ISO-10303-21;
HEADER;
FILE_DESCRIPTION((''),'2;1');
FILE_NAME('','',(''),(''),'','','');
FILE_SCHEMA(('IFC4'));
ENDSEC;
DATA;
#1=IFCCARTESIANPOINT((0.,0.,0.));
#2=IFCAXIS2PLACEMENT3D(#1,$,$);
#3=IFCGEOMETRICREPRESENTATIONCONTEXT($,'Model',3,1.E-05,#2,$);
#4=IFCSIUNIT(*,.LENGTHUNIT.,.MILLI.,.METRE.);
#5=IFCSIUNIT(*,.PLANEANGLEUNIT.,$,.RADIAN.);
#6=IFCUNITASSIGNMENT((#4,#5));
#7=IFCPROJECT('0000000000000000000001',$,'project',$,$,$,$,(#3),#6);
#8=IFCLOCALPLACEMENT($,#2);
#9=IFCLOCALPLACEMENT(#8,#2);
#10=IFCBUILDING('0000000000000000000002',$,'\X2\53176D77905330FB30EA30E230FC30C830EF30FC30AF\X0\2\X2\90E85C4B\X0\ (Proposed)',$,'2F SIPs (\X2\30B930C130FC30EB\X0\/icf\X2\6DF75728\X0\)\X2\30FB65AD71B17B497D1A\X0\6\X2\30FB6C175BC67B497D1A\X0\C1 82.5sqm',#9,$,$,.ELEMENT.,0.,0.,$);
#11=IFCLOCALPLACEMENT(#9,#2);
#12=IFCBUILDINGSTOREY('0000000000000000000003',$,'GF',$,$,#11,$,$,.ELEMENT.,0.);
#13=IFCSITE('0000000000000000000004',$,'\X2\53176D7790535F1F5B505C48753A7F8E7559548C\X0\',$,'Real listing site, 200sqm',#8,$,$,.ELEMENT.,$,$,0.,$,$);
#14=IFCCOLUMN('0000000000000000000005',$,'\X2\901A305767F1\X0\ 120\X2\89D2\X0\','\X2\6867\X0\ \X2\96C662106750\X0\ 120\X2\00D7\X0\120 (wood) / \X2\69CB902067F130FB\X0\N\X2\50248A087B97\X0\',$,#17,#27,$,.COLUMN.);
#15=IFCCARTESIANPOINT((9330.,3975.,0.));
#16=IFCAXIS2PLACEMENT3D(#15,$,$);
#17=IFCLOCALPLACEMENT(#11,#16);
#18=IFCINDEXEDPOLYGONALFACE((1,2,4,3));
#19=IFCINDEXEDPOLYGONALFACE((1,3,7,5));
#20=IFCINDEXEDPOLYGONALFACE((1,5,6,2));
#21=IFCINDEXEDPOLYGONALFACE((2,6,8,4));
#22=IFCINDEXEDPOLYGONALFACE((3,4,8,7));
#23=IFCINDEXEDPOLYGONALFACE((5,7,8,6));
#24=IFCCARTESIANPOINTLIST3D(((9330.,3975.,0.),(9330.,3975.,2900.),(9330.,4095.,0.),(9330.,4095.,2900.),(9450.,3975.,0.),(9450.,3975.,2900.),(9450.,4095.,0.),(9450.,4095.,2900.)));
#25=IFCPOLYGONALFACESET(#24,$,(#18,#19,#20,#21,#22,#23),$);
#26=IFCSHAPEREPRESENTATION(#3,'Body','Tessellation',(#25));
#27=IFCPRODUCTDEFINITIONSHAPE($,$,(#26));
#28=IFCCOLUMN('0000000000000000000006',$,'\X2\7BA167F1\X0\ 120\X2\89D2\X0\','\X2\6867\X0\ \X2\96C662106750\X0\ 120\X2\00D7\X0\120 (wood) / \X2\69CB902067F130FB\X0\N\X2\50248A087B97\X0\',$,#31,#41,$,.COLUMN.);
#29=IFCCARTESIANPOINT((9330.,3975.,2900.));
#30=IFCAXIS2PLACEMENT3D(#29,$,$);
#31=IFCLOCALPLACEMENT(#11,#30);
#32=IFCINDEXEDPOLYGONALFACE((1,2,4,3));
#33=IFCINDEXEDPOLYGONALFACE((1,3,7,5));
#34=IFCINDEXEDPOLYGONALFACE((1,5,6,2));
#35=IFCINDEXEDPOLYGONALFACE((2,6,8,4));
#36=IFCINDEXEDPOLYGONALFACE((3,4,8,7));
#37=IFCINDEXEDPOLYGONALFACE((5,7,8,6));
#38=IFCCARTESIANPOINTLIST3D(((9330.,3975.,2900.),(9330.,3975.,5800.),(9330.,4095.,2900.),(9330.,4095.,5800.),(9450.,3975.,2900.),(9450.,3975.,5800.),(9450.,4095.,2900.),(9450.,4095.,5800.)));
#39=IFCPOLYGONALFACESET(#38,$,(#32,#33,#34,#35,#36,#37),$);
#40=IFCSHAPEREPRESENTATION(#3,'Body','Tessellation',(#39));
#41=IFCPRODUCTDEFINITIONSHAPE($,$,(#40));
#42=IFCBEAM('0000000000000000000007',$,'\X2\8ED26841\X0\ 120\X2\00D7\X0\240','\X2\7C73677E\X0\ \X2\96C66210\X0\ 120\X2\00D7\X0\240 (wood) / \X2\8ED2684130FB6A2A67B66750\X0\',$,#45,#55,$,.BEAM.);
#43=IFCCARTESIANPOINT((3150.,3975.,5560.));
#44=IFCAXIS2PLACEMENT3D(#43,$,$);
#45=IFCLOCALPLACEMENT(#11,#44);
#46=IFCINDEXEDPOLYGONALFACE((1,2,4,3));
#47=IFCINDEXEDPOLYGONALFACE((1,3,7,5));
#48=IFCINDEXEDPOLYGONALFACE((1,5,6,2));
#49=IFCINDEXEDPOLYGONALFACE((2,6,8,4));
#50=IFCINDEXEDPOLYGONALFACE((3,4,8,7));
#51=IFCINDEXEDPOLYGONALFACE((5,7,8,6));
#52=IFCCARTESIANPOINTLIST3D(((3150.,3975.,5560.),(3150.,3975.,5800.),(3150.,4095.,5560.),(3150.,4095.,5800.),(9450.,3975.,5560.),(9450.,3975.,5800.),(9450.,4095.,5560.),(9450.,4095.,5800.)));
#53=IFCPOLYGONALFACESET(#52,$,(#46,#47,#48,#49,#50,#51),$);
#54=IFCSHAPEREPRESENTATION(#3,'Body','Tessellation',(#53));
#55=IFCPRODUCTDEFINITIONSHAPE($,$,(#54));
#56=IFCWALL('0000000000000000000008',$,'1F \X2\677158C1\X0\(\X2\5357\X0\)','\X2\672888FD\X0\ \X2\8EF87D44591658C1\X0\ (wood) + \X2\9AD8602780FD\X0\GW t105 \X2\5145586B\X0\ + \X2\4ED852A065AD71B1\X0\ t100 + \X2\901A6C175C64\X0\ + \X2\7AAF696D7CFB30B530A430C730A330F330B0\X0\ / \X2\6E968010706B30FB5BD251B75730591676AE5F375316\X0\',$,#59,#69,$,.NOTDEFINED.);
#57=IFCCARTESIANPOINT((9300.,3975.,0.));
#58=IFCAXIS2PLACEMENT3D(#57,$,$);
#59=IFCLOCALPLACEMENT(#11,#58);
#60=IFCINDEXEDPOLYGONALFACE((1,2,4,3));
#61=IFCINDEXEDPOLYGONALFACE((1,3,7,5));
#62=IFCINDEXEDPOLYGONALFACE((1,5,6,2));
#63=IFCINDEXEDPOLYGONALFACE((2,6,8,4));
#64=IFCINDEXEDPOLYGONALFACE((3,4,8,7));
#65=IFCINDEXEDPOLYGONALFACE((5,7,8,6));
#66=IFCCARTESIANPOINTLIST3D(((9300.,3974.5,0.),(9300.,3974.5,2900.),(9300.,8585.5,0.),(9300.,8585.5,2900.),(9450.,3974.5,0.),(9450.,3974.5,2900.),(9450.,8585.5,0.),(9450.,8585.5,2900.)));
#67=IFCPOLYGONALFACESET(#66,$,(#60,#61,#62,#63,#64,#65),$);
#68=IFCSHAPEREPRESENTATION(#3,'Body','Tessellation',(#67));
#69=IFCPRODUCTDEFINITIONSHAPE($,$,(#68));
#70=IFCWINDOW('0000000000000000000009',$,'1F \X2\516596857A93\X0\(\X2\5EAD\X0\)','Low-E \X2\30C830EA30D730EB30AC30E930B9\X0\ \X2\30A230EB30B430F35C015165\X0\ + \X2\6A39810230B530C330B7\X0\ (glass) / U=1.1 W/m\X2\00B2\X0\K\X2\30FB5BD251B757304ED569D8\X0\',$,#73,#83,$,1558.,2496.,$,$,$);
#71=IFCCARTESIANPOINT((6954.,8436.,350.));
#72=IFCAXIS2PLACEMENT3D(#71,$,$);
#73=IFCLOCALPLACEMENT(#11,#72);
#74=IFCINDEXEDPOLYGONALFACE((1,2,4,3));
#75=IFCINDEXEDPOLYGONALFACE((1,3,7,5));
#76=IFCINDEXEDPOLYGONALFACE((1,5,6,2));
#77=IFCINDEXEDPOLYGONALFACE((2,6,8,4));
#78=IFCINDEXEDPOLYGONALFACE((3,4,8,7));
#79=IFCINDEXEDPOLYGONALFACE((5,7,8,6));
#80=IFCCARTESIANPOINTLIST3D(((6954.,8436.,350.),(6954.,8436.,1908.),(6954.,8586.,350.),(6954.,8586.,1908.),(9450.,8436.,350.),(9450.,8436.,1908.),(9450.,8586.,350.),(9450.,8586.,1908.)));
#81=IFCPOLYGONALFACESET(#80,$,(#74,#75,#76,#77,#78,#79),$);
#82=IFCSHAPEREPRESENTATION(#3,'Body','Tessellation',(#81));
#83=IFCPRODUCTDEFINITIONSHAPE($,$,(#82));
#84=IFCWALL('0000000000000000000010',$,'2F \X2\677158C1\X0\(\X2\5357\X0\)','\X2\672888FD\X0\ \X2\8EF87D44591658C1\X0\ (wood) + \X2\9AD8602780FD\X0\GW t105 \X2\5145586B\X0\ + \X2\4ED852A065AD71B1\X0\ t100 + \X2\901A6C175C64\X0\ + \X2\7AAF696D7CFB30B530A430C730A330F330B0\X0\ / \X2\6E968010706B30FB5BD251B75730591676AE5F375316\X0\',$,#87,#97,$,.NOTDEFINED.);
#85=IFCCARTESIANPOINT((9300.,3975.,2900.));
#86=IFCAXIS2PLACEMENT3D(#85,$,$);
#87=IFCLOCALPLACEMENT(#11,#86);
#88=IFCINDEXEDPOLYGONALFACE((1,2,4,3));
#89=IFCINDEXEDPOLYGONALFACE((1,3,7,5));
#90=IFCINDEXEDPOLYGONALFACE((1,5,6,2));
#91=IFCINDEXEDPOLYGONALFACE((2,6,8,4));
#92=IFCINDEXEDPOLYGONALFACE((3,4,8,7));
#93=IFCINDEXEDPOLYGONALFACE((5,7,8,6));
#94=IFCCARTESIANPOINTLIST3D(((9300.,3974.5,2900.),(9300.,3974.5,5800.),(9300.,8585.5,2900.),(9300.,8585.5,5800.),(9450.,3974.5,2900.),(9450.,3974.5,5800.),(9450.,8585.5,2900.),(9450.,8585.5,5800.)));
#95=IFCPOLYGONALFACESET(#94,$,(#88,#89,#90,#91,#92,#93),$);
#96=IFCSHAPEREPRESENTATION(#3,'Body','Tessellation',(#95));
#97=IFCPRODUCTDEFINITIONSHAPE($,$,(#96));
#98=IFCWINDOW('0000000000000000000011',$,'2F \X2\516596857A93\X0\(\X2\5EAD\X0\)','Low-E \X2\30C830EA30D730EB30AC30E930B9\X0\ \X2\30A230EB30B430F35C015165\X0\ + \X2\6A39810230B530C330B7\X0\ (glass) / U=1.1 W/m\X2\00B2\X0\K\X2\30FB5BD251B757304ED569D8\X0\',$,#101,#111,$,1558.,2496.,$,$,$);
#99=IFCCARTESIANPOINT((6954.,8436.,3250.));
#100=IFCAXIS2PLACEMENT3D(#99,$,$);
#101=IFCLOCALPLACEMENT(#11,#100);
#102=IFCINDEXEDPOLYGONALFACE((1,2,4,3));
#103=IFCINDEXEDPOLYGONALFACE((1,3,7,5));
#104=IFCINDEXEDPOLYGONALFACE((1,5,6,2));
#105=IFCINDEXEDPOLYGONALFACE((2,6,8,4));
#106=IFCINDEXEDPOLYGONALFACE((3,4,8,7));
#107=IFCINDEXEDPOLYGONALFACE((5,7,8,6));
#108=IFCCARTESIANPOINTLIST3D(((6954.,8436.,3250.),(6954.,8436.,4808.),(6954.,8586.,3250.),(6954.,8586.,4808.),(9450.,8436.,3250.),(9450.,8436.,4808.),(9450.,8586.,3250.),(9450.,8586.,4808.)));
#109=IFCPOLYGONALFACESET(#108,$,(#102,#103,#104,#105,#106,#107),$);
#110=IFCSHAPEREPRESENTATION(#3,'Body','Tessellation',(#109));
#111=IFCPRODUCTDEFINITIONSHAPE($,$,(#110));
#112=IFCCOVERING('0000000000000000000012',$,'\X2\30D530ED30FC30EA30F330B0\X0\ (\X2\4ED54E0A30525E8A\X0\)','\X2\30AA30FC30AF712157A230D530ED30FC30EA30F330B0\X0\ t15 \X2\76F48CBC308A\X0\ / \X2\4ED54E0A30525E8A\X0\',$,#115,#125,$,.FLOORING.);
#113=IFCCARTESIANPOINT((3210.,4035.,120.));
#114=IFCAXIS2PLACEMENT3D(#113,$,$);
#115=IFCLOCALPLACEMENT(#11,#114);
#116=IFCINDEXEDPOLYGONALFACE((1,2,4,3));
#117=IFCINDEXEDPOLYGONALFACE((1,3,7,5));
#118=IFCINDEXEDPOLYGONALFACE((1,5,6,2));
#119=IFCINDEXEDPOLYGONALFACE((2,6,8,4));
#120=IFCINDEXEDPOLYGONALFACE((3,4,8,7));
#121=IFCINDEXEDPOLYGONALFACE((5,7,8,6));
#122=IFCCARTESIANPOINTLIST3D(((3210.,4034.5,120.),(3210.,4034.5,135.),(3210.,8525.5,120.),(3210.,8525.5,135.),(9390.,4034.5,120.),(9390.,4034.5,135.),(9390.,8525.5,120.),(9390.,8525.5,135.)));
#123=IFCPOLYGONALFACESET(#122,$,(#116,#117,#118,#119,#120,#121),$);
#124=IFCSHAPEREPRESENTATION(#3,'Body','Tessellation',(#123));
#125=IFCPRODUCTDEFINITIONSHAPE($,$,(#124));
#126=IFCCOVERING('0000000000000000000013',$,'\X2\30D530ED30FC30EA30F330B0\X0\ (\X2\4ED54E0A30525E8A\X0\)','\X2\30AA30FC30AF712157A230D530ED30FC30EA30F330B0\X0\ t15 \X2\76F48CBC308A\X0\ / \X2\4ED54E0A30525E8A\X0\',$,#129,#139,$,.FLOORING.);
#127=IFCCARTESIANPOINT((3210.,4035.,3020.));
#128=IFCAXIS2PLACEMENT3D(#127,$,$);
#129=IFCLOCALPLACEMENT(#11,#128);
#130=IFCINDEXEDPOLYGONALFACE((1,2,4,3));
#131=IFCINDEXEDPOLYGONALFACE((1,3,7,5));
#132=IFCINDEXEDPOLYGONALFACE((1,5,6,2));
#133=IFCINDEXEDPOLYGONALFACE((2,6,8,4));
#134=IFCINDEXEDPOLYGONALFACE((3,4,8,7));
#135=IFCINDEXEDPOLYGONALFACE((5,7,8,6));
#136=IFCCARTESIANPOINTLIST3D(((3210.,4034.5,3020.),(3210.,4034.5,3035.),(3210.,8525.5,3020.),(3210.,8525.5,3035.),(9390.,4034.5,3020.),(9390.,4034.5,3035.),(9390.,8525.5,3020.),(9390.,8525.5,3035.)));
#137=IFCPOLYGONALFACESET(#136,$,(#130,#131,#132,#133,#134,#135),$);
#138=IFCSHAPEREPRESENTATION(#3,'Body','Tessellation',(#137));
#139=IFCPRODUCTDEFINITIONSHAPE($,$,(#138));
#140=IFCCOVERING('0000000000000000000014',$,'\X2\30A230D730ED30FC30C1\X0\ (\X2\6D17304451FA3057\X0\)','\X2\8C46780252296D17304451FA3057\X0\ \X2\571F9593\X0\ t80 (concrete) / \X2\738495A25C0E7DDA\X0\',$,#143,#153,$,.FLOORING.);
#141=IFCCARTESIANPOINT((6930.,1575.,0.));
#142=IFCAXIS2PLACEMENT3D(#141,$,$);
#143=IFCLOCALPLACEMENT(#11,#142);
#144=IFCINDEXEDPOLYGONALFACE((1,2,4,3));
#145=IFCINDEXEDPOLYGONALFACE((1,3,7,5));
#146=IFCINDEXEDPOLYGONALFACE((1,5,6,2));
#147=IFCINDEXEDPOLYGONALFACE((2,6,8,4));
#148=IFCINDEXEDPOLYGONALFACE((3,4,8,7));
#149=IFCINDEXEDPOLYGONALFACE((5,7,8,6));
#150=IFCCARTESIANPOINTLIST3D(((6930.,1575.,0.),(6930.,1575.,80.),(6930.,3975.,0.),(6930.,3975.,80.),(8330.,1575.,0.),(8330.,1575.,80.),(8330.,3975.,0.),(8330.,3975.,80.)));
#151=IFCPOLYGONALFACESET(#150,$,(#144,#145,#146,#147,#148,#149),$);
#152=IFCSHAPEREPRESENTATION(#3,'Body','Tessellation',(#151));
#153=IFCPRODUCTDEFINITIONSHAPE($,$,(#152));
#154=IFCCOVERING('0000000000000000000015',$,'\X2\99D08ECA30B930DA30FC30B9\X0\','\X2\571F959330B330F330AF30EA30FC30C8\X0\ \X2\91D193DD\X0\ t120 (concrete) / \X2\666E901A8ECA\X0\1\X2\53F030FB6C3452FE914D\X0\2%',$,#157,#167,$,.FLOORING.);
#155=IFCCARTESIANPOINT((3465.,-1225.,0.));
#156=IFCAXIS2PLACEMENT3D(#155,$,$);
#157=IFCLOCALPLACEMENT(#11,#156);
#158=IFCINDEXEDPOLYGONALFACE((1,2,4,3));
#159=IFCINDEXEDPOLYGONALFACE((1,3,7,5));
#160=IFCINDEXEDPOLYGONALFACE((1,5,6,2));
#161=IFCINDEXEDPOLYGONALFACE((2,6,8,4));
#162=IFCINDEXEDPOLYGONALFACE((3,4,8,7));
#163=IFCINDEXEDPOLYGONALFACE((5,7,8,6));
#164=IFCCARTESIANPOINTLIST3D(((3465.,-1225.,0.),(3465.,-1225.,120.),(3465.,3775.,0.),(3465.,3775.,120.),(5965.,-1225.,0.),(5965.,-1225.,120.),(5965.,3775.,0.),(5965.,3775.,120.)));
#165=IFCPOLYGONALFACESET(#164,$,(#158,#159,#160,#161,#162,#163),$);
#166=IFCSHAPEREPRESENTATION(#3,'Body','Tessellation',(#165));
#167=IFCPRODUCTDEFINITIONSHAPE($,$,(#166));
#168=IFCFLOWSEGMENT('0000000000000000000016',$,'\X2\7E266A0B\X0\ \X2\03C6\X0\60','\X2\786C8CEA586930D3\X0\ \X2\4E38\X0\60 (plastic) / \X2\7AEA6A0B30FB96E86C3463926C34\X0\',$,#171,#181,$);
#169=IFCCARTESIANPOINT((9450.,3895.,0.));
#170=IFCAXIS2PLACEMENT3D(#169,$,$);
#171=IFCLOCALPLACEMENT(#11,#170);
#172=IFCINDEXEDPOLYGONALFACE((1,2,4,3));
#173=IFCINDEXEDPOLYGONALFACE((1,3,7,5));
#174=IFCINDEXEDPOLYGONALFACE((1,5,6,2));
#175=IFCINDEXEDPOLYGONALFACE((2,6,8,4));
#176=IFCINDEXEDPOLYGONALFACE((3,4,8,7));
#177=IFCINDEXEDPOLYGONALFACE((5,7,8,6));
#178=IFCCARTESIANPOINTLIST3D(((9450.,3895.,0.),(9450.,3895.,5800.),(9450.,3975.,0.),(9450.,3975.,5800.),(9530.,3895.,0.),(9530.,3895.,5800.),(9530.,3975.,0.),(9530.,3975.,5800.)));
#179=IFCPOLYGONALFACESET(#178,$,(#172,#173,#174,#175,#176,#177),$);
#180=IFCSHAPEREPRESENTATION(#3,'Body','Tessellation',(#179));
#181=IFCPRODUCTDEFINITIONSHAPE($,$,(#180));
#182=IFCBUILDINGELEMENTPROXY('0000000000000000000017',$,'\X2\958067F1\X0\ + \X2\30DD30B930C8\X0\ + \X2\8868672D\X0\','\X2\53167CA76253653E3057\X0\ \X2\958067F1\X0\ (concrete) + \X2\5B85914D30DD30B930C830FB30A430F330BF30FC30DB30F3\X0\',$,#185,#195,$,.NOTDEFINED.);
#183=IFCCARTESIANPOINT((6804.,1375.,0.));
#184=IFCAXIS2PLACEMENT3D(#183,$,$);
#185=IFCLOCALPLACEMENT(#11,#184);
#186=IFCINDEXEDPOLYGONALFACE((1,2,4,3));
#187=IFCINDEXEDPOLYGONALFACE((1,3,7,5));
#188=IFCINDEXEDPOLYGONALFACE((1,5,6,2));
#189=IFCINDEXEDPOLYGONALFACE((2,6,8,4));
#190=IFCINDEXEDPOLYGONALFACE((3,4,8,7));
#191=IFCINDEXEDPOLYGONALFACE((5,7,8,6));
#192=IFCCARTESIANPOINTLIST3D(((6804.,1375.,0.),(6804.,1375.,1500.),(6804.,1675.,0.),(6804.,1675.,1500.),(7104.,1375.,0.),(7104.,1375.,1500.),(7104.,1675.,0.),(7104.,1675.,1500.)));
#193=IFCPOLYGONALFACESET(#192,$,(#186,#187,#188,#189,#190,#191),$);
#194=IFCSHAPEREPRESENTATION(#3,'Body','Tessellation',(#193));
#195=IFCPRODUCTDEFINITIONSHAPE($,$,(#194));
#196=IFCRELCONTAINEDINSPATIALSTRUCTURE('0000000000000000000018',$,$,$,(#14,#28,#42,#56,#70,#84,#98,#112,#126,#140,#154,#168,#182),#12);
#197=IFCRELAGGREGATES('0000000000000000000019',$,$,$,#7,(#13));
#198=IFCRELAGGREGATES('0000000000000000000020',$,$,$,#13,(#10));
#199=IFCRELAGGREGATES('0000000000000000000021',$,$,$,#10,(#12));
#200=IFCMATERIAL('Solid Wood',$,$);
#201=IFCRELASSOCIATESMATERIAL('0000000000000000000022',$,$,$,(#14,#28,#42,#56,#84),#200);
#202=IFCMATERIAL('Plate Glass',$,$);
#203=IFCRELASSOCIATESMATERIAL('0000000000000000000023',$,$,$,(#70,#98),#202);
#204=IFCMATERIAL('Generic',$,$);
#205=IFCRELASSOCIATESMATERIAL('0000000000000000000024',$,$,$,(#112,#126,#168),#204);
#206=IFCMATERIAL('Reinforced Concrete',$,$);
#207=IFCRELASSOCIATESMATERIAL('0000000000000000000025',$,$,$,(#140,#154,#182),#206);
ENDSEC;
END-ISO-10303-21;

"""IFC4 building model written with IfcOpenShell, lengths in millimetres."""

from ifc_helpers import new_model, si_unit, frame, frame_2d, origin, place, context, project, spatial, rectangle, extrude, material, element, fill, save


model = new_model("IFC4")

# Units and contexts
model_context = context("Model", 3, precision=1e-05, world=origin())
ifc_project = project(units=[si_unit("LENGTHUNIT", "METRE", prefix="MILLI"), si_unit("PLANEANGLEUNIT", "RADIAN")], contexts=[model_context])

# Site, building, storey
site_placement = place(None, origin())
site = spatial("IfcSite", under=ifc_project, at=site_placement, Name="北海道弟子屈町美留和", ObjectType="Real listing site, 200sqm", CompositionType="ELEMENT", RefElevation=0.0)
building_placement = place(site_placement, origin())
building = spatial("IfcBuilding", under=site, at=building_placement, Name="北海道・リモートワーク2部屋 (Proposed)", ObjectType="2F SIPs (スチール/icf混在)・断熱等級6・気密等級C1 82.5sqm", CompositionType="ELEMENT", ElevationOfRefHeight=0.0, ElevationOfTerrain=0.0)
storey_placement = place(building_placement, origin())
storey = spatial("IfcBuildingStorey", under=building, at=storey_placement, Name="GF", CompositionType="ELEMENT", Elevation=0.0)

# Columns
ifc_material_1 = material(Name="Solid Wood")
column_1_placement = place(storey_placement, frame((9330.0, 3975.0, 0.0)))
element("IfcColumn", 1, at=column_1_placement, inside=storey, material=ifc_material_1, Name="通し柱 120角", Description="桧 集成材 120×120 (wood) / 構造柱・N値計算", PredefinedType="COLUMN", context=model_context, shape_type="SweptSolid", body=[
    extrude(rectangle(XDim=120.0, YDim=120.0, at=frame_2d((60.0, 60.0))), frame((9330.0, 3975.0, 0.0)), (0.0, 0.0, 1.0), 2900.0),
])
column_2_placement = place(storey_placement, frame((9330.0, 3975.0, 2900.0)))
element("IfcColumn", 2, at=column_2_placement, inside=storey, material=ifc_material_1, Name="管柱 120角", Description="桧 集成材 120×120 (wood) / 構造柱・N値計算", PredefinedType="COLUMN", context=model_context, shape_type="SweptSolid", body=[
    extrude(rectangle(XDim=120.0, YDim=120.0, at=frame_2d((60.0, 60.0))), frame((9330.0, 3975.0, 2900.0)), (0.0, 0.0, 1.0), 2900.0),
])

# Beam
beam_1_placement = place(storey_placement, frame((3150.0, 3975.0, 5560.0)))
element("IfcBeam", 3, at=beam_1_placement, inside=storey, material=ifc_material_1, Name="軒桁 120×240", Description="米松 集成 120×240 (wood) / 軒桁・横架材", PredefinedType="BEAM", context=model_context, shape_type="SweptSolid", body=[
    extrude(rectangle(XDim=6300.0, YDim=120.0, at=frame_2d((3150.0, 60.0))), frame((3150.0, 3975.0, 5560.0)), (0.0, 0.0, 1.0), 240.0),
])

# Wall, opening, window
wall_1_placement = place(storey_placement, frame((9300.0, 3975.0, 0.0)))
wall_1 = element("IfcWall", 4, at=wall_1_placement, inside=storey, material=ifc_material_1, Name="1F 東壁(南)", Description="木製 軸組外壁 (wood) + 高性能GW t105 充填 + 付加断熱 t100 + 通気層 + 窯業系サイディング / 準耐火・寒冷地外皮強化", PredefinedType="NOTDEFINED", context=model_context, shape_type="SweptSolid", body=[
    extrude(rectangle(XDim=150.0, YDim=4611.0, at=frame_2d((75.0, 2305.0))), frame((9300.0, 3975.0, 0.0)), (0.0, 0.0, 1.0), 2900.0),
])
opening_1_placement = place(storey_placement, frame((6954.0, 8436.0, 350.0)))
opening_1 = element("IfcOpeningElement", 5, at=opening_1_placement, cuts=wall_1, PredefinedType="NOTDEFINED", context=model_context, shape_type="SweptSolid", body=[
    extrude(rectangle(XDim=2496.0, YDim=150.0, at=frame_2d((1248.0, 75.0))), frame((6954.0, 8436.0, 350.0)), (0.0, 0.0, 1.0), 1558.0),
])
ifc_material_2 = material(Name="Plate Glass")
window_1_placement = place(storey_placement, frame((6954.0, 8436.0, 350.0)))
window_1 = element("IfcWindow", 6, at=window_1_placement, inside=storey, material=ifc_material_2, Name="1F 入隅窓(庭)", Description="Low-E トリプルガラス アルゴン封入 + 樹脂サッシ (glass) / U=1.1 W/m²K・寒冷地仕様", OverallHeight=1558.0, OverallWidth=2496.0, context=model_context, shape_type="SweptSolid", body=[
    extrude(rectangle(XDim=2496.0, YDim=150.0, at=frame_2d((1248.0, 75.0))), frame((6954.0, 8436.0, 350.0)), (0.0, 0.0, 1.0), 1558.0),
])
fill(opening_1, window_1)

# Wall, opening, window
wall_2_placement = place(storey_placement, frame((9300.0, 3975.0, 2900.0)))
wall_2 = element("IfcWall", 7, at=wall_2_placement, inside=storey, material=ifc_material_1, Name="2F 東壁(南)", Description="木製 軸組外壁 (wood) + 高性能GW t105 充填 + 付加断熱 t100 + 通気層 + 窯業系サイディング / 準耐火・寒冷地外皮強化", PredefinedType="NOTDEFINED", context=model_context, shape_type="SweptSolid", body=[
    extrude(rectangle(XDim=150.0, YDim=4611.0, at=frame_2d((75.0, 2305.0))), frame((9300.0, 3975.0, 2900.0)), (0.0, 0.0, 1.0), 2900.0),
])
opening_2_placement = place(storey_placement, frame((6954.0, 8436.0, 3250.0)))
opening_2 = element("IfcOpeningElement", 8, at=opening_2_placement, cuts=wall_2, PredefinedType="NOTDEFINED", context=model_context, shape_type="SweptSolid", body=[
    extrude(rectangle(XDim=2496.0, YDim=150.0, at=frame_2d((1248.0, 75.0))), frame((6954.0, 8436.0, 3250.0)), (0.0, 0.0, 1.0), 1558.0),
])
window_2_placement = place(storey_placement, frame((6954.0, 8436.0, 3250.0)))
window_2 = element("IfcWindow", 9, at=window_2_placement, inside=storey, material=ifc_material_2, Name="2F 入隅窓(庭)", Description="Low-E トリプルガラス アルゴン封入 + 樹脂サッシ (glass) / U=1.1 W/m²K・寒冷地仕様", OverallHeight=1558.0, OverallWidth=2496.0, context=model_context, shape_type="SweptSolid", body=[
    extrude(rectangle(XDim=2496.0, YDim=150.0, at=frame_2d((1248.0, 75.0))), frame((6954.0, 8436.0, 3250.0)), (0.0, 0.0, 1.0), 1558.0),
])
fill(opening_2, window_2)

# Coverings
ifc_material_3 = material(Name="Generic")
covering_1_placement = place(storey_placement, frame((3210.0, 4035.0, 120.0)))
element("IfcCovering", 10, at=covering_1_placement, inside=storey, material=ifc_material_3, Name="フローリング (仕上げ床)", Description="オーク無垢フローリング t15 直貼り / 仕上げ床", PredefinedType="FLOORING", context=model_context, shape_type="SweptSolid", body=[
    extrude(rectangle(XDim=6180.0, YDim=4491.0, at=frame_2d((3090.0, 2245.0))), frame((3210.0, 4035.0, 120.0)), (0.0, 0.0, 1.0), 15.0),
])
covering_2_placement = place(storey_placement, frame((3210.0, 4035.0, 3020.0)))
element("IfcCovering", 11, at=covering_2_placement, inside=storey, material=ifc_material_3, Name="フローリング (仕上げ床)", Description="オーク無垢フローリング t15 直貼り / 仕上げ床", PredefinedType="FLOORING", context=model_context, shape_type="SweptSolid", body=[
    extrude(rectangle(XDim=6180.0, YDim=4491.0, at=frame_2d((3090.0, 2245.0))), frame((3210.0, 4035.0, 3020.0)), (0.0, 0.0, 1.0), 15.0),
])
ifc_material_4 = material(Name="Reinforced Concrete")
covering_3_placement = place(storey_placement, frame((6930.0, 1575.0, 0.0)))
element("IfcCovering", 12, at=covering_3_placement, inside=storey, material=ifc_material_4, Name="アプローチ (洗い出し)", Description="豆砂利洗い出し 土間 t80 (concrete) / 玄関導線", PredefinedType="FLOORING", context=model_context, shape_type="SweptSolid", body=[
    extrude(rectangle(XDim=1400.0, YDim=2400.0, at=frame_2d((700.0, 1200.0))), frame((6930.0, 1575.0, 0.0)), (0.0, 0.0, 1.0), 80.0),
])
covering_4_placement = place(storey_placement, frame((3465.0, -1225.0, 0.0)))
element("IfcCovering", 13, at=covering_4_placement, inside=storey, material=ifc_material_4, Name="駐車スペース", Description="土間コンクリート 金鏝 t120 (concrete) / 普通車1台・水勾配2%", PredefinedType="FLOORING", context=model_context, shape_type="SweptSolid", body=[
    extrude(rectangle(XDim=2500.0, YDim=5000.0, at=frame_2d((1250.0, 2500.0))), frame((3465.0, -1225.0, 0.0)), (0.0, 0.0, 1.0), 120.0),
])

# Flow segment
flow_segment_placement = place(storey_placement, frame((9450.0, 3895.0, 0.0)))
element("IfcFlowSegment", 14, at=flow_segment_placement, inside=storey, material=ifc_material_3, Name="縦樋 φ60", Description="硬質塩ビ 丸60 (plastic) / 竪樋・雨水排水", context=model_context, shape_type="SweptSolid", body=[
    extrude(rectangle(XDim=80.0, YDim=80.0, at=frame_2d((40.0, 40.0))), frame((9450.0, 3895.0, 0.0)), (0.0, 0.0, 1.0), 5800.0),
])

# Building element proxy
proxy_placement = place(storey_placement, frame((6804.0, 1375.0, 0.0)))
element("IfcBuildingElementProxy", 15, at=proxy_placement, inside=storey, material=ifc_material_4, Name="門柱 + ポスト + 表札", Description="化粧打放し 門柱 (concrete) + 宅配ポスト・インターホン", PredefinedType="NOTDEFINED", context=model_context, shape_type="SweptSolid", body=[
    extrude(rectangle(XDim=300.0, YDim=300.0, at=frame_2d((150.0, 150.0))), frame((6804.0, 1375.0, 0.0)), (0.0, 0.0, 1.0), 1500.0),
])

save(model, "model.ifc")
